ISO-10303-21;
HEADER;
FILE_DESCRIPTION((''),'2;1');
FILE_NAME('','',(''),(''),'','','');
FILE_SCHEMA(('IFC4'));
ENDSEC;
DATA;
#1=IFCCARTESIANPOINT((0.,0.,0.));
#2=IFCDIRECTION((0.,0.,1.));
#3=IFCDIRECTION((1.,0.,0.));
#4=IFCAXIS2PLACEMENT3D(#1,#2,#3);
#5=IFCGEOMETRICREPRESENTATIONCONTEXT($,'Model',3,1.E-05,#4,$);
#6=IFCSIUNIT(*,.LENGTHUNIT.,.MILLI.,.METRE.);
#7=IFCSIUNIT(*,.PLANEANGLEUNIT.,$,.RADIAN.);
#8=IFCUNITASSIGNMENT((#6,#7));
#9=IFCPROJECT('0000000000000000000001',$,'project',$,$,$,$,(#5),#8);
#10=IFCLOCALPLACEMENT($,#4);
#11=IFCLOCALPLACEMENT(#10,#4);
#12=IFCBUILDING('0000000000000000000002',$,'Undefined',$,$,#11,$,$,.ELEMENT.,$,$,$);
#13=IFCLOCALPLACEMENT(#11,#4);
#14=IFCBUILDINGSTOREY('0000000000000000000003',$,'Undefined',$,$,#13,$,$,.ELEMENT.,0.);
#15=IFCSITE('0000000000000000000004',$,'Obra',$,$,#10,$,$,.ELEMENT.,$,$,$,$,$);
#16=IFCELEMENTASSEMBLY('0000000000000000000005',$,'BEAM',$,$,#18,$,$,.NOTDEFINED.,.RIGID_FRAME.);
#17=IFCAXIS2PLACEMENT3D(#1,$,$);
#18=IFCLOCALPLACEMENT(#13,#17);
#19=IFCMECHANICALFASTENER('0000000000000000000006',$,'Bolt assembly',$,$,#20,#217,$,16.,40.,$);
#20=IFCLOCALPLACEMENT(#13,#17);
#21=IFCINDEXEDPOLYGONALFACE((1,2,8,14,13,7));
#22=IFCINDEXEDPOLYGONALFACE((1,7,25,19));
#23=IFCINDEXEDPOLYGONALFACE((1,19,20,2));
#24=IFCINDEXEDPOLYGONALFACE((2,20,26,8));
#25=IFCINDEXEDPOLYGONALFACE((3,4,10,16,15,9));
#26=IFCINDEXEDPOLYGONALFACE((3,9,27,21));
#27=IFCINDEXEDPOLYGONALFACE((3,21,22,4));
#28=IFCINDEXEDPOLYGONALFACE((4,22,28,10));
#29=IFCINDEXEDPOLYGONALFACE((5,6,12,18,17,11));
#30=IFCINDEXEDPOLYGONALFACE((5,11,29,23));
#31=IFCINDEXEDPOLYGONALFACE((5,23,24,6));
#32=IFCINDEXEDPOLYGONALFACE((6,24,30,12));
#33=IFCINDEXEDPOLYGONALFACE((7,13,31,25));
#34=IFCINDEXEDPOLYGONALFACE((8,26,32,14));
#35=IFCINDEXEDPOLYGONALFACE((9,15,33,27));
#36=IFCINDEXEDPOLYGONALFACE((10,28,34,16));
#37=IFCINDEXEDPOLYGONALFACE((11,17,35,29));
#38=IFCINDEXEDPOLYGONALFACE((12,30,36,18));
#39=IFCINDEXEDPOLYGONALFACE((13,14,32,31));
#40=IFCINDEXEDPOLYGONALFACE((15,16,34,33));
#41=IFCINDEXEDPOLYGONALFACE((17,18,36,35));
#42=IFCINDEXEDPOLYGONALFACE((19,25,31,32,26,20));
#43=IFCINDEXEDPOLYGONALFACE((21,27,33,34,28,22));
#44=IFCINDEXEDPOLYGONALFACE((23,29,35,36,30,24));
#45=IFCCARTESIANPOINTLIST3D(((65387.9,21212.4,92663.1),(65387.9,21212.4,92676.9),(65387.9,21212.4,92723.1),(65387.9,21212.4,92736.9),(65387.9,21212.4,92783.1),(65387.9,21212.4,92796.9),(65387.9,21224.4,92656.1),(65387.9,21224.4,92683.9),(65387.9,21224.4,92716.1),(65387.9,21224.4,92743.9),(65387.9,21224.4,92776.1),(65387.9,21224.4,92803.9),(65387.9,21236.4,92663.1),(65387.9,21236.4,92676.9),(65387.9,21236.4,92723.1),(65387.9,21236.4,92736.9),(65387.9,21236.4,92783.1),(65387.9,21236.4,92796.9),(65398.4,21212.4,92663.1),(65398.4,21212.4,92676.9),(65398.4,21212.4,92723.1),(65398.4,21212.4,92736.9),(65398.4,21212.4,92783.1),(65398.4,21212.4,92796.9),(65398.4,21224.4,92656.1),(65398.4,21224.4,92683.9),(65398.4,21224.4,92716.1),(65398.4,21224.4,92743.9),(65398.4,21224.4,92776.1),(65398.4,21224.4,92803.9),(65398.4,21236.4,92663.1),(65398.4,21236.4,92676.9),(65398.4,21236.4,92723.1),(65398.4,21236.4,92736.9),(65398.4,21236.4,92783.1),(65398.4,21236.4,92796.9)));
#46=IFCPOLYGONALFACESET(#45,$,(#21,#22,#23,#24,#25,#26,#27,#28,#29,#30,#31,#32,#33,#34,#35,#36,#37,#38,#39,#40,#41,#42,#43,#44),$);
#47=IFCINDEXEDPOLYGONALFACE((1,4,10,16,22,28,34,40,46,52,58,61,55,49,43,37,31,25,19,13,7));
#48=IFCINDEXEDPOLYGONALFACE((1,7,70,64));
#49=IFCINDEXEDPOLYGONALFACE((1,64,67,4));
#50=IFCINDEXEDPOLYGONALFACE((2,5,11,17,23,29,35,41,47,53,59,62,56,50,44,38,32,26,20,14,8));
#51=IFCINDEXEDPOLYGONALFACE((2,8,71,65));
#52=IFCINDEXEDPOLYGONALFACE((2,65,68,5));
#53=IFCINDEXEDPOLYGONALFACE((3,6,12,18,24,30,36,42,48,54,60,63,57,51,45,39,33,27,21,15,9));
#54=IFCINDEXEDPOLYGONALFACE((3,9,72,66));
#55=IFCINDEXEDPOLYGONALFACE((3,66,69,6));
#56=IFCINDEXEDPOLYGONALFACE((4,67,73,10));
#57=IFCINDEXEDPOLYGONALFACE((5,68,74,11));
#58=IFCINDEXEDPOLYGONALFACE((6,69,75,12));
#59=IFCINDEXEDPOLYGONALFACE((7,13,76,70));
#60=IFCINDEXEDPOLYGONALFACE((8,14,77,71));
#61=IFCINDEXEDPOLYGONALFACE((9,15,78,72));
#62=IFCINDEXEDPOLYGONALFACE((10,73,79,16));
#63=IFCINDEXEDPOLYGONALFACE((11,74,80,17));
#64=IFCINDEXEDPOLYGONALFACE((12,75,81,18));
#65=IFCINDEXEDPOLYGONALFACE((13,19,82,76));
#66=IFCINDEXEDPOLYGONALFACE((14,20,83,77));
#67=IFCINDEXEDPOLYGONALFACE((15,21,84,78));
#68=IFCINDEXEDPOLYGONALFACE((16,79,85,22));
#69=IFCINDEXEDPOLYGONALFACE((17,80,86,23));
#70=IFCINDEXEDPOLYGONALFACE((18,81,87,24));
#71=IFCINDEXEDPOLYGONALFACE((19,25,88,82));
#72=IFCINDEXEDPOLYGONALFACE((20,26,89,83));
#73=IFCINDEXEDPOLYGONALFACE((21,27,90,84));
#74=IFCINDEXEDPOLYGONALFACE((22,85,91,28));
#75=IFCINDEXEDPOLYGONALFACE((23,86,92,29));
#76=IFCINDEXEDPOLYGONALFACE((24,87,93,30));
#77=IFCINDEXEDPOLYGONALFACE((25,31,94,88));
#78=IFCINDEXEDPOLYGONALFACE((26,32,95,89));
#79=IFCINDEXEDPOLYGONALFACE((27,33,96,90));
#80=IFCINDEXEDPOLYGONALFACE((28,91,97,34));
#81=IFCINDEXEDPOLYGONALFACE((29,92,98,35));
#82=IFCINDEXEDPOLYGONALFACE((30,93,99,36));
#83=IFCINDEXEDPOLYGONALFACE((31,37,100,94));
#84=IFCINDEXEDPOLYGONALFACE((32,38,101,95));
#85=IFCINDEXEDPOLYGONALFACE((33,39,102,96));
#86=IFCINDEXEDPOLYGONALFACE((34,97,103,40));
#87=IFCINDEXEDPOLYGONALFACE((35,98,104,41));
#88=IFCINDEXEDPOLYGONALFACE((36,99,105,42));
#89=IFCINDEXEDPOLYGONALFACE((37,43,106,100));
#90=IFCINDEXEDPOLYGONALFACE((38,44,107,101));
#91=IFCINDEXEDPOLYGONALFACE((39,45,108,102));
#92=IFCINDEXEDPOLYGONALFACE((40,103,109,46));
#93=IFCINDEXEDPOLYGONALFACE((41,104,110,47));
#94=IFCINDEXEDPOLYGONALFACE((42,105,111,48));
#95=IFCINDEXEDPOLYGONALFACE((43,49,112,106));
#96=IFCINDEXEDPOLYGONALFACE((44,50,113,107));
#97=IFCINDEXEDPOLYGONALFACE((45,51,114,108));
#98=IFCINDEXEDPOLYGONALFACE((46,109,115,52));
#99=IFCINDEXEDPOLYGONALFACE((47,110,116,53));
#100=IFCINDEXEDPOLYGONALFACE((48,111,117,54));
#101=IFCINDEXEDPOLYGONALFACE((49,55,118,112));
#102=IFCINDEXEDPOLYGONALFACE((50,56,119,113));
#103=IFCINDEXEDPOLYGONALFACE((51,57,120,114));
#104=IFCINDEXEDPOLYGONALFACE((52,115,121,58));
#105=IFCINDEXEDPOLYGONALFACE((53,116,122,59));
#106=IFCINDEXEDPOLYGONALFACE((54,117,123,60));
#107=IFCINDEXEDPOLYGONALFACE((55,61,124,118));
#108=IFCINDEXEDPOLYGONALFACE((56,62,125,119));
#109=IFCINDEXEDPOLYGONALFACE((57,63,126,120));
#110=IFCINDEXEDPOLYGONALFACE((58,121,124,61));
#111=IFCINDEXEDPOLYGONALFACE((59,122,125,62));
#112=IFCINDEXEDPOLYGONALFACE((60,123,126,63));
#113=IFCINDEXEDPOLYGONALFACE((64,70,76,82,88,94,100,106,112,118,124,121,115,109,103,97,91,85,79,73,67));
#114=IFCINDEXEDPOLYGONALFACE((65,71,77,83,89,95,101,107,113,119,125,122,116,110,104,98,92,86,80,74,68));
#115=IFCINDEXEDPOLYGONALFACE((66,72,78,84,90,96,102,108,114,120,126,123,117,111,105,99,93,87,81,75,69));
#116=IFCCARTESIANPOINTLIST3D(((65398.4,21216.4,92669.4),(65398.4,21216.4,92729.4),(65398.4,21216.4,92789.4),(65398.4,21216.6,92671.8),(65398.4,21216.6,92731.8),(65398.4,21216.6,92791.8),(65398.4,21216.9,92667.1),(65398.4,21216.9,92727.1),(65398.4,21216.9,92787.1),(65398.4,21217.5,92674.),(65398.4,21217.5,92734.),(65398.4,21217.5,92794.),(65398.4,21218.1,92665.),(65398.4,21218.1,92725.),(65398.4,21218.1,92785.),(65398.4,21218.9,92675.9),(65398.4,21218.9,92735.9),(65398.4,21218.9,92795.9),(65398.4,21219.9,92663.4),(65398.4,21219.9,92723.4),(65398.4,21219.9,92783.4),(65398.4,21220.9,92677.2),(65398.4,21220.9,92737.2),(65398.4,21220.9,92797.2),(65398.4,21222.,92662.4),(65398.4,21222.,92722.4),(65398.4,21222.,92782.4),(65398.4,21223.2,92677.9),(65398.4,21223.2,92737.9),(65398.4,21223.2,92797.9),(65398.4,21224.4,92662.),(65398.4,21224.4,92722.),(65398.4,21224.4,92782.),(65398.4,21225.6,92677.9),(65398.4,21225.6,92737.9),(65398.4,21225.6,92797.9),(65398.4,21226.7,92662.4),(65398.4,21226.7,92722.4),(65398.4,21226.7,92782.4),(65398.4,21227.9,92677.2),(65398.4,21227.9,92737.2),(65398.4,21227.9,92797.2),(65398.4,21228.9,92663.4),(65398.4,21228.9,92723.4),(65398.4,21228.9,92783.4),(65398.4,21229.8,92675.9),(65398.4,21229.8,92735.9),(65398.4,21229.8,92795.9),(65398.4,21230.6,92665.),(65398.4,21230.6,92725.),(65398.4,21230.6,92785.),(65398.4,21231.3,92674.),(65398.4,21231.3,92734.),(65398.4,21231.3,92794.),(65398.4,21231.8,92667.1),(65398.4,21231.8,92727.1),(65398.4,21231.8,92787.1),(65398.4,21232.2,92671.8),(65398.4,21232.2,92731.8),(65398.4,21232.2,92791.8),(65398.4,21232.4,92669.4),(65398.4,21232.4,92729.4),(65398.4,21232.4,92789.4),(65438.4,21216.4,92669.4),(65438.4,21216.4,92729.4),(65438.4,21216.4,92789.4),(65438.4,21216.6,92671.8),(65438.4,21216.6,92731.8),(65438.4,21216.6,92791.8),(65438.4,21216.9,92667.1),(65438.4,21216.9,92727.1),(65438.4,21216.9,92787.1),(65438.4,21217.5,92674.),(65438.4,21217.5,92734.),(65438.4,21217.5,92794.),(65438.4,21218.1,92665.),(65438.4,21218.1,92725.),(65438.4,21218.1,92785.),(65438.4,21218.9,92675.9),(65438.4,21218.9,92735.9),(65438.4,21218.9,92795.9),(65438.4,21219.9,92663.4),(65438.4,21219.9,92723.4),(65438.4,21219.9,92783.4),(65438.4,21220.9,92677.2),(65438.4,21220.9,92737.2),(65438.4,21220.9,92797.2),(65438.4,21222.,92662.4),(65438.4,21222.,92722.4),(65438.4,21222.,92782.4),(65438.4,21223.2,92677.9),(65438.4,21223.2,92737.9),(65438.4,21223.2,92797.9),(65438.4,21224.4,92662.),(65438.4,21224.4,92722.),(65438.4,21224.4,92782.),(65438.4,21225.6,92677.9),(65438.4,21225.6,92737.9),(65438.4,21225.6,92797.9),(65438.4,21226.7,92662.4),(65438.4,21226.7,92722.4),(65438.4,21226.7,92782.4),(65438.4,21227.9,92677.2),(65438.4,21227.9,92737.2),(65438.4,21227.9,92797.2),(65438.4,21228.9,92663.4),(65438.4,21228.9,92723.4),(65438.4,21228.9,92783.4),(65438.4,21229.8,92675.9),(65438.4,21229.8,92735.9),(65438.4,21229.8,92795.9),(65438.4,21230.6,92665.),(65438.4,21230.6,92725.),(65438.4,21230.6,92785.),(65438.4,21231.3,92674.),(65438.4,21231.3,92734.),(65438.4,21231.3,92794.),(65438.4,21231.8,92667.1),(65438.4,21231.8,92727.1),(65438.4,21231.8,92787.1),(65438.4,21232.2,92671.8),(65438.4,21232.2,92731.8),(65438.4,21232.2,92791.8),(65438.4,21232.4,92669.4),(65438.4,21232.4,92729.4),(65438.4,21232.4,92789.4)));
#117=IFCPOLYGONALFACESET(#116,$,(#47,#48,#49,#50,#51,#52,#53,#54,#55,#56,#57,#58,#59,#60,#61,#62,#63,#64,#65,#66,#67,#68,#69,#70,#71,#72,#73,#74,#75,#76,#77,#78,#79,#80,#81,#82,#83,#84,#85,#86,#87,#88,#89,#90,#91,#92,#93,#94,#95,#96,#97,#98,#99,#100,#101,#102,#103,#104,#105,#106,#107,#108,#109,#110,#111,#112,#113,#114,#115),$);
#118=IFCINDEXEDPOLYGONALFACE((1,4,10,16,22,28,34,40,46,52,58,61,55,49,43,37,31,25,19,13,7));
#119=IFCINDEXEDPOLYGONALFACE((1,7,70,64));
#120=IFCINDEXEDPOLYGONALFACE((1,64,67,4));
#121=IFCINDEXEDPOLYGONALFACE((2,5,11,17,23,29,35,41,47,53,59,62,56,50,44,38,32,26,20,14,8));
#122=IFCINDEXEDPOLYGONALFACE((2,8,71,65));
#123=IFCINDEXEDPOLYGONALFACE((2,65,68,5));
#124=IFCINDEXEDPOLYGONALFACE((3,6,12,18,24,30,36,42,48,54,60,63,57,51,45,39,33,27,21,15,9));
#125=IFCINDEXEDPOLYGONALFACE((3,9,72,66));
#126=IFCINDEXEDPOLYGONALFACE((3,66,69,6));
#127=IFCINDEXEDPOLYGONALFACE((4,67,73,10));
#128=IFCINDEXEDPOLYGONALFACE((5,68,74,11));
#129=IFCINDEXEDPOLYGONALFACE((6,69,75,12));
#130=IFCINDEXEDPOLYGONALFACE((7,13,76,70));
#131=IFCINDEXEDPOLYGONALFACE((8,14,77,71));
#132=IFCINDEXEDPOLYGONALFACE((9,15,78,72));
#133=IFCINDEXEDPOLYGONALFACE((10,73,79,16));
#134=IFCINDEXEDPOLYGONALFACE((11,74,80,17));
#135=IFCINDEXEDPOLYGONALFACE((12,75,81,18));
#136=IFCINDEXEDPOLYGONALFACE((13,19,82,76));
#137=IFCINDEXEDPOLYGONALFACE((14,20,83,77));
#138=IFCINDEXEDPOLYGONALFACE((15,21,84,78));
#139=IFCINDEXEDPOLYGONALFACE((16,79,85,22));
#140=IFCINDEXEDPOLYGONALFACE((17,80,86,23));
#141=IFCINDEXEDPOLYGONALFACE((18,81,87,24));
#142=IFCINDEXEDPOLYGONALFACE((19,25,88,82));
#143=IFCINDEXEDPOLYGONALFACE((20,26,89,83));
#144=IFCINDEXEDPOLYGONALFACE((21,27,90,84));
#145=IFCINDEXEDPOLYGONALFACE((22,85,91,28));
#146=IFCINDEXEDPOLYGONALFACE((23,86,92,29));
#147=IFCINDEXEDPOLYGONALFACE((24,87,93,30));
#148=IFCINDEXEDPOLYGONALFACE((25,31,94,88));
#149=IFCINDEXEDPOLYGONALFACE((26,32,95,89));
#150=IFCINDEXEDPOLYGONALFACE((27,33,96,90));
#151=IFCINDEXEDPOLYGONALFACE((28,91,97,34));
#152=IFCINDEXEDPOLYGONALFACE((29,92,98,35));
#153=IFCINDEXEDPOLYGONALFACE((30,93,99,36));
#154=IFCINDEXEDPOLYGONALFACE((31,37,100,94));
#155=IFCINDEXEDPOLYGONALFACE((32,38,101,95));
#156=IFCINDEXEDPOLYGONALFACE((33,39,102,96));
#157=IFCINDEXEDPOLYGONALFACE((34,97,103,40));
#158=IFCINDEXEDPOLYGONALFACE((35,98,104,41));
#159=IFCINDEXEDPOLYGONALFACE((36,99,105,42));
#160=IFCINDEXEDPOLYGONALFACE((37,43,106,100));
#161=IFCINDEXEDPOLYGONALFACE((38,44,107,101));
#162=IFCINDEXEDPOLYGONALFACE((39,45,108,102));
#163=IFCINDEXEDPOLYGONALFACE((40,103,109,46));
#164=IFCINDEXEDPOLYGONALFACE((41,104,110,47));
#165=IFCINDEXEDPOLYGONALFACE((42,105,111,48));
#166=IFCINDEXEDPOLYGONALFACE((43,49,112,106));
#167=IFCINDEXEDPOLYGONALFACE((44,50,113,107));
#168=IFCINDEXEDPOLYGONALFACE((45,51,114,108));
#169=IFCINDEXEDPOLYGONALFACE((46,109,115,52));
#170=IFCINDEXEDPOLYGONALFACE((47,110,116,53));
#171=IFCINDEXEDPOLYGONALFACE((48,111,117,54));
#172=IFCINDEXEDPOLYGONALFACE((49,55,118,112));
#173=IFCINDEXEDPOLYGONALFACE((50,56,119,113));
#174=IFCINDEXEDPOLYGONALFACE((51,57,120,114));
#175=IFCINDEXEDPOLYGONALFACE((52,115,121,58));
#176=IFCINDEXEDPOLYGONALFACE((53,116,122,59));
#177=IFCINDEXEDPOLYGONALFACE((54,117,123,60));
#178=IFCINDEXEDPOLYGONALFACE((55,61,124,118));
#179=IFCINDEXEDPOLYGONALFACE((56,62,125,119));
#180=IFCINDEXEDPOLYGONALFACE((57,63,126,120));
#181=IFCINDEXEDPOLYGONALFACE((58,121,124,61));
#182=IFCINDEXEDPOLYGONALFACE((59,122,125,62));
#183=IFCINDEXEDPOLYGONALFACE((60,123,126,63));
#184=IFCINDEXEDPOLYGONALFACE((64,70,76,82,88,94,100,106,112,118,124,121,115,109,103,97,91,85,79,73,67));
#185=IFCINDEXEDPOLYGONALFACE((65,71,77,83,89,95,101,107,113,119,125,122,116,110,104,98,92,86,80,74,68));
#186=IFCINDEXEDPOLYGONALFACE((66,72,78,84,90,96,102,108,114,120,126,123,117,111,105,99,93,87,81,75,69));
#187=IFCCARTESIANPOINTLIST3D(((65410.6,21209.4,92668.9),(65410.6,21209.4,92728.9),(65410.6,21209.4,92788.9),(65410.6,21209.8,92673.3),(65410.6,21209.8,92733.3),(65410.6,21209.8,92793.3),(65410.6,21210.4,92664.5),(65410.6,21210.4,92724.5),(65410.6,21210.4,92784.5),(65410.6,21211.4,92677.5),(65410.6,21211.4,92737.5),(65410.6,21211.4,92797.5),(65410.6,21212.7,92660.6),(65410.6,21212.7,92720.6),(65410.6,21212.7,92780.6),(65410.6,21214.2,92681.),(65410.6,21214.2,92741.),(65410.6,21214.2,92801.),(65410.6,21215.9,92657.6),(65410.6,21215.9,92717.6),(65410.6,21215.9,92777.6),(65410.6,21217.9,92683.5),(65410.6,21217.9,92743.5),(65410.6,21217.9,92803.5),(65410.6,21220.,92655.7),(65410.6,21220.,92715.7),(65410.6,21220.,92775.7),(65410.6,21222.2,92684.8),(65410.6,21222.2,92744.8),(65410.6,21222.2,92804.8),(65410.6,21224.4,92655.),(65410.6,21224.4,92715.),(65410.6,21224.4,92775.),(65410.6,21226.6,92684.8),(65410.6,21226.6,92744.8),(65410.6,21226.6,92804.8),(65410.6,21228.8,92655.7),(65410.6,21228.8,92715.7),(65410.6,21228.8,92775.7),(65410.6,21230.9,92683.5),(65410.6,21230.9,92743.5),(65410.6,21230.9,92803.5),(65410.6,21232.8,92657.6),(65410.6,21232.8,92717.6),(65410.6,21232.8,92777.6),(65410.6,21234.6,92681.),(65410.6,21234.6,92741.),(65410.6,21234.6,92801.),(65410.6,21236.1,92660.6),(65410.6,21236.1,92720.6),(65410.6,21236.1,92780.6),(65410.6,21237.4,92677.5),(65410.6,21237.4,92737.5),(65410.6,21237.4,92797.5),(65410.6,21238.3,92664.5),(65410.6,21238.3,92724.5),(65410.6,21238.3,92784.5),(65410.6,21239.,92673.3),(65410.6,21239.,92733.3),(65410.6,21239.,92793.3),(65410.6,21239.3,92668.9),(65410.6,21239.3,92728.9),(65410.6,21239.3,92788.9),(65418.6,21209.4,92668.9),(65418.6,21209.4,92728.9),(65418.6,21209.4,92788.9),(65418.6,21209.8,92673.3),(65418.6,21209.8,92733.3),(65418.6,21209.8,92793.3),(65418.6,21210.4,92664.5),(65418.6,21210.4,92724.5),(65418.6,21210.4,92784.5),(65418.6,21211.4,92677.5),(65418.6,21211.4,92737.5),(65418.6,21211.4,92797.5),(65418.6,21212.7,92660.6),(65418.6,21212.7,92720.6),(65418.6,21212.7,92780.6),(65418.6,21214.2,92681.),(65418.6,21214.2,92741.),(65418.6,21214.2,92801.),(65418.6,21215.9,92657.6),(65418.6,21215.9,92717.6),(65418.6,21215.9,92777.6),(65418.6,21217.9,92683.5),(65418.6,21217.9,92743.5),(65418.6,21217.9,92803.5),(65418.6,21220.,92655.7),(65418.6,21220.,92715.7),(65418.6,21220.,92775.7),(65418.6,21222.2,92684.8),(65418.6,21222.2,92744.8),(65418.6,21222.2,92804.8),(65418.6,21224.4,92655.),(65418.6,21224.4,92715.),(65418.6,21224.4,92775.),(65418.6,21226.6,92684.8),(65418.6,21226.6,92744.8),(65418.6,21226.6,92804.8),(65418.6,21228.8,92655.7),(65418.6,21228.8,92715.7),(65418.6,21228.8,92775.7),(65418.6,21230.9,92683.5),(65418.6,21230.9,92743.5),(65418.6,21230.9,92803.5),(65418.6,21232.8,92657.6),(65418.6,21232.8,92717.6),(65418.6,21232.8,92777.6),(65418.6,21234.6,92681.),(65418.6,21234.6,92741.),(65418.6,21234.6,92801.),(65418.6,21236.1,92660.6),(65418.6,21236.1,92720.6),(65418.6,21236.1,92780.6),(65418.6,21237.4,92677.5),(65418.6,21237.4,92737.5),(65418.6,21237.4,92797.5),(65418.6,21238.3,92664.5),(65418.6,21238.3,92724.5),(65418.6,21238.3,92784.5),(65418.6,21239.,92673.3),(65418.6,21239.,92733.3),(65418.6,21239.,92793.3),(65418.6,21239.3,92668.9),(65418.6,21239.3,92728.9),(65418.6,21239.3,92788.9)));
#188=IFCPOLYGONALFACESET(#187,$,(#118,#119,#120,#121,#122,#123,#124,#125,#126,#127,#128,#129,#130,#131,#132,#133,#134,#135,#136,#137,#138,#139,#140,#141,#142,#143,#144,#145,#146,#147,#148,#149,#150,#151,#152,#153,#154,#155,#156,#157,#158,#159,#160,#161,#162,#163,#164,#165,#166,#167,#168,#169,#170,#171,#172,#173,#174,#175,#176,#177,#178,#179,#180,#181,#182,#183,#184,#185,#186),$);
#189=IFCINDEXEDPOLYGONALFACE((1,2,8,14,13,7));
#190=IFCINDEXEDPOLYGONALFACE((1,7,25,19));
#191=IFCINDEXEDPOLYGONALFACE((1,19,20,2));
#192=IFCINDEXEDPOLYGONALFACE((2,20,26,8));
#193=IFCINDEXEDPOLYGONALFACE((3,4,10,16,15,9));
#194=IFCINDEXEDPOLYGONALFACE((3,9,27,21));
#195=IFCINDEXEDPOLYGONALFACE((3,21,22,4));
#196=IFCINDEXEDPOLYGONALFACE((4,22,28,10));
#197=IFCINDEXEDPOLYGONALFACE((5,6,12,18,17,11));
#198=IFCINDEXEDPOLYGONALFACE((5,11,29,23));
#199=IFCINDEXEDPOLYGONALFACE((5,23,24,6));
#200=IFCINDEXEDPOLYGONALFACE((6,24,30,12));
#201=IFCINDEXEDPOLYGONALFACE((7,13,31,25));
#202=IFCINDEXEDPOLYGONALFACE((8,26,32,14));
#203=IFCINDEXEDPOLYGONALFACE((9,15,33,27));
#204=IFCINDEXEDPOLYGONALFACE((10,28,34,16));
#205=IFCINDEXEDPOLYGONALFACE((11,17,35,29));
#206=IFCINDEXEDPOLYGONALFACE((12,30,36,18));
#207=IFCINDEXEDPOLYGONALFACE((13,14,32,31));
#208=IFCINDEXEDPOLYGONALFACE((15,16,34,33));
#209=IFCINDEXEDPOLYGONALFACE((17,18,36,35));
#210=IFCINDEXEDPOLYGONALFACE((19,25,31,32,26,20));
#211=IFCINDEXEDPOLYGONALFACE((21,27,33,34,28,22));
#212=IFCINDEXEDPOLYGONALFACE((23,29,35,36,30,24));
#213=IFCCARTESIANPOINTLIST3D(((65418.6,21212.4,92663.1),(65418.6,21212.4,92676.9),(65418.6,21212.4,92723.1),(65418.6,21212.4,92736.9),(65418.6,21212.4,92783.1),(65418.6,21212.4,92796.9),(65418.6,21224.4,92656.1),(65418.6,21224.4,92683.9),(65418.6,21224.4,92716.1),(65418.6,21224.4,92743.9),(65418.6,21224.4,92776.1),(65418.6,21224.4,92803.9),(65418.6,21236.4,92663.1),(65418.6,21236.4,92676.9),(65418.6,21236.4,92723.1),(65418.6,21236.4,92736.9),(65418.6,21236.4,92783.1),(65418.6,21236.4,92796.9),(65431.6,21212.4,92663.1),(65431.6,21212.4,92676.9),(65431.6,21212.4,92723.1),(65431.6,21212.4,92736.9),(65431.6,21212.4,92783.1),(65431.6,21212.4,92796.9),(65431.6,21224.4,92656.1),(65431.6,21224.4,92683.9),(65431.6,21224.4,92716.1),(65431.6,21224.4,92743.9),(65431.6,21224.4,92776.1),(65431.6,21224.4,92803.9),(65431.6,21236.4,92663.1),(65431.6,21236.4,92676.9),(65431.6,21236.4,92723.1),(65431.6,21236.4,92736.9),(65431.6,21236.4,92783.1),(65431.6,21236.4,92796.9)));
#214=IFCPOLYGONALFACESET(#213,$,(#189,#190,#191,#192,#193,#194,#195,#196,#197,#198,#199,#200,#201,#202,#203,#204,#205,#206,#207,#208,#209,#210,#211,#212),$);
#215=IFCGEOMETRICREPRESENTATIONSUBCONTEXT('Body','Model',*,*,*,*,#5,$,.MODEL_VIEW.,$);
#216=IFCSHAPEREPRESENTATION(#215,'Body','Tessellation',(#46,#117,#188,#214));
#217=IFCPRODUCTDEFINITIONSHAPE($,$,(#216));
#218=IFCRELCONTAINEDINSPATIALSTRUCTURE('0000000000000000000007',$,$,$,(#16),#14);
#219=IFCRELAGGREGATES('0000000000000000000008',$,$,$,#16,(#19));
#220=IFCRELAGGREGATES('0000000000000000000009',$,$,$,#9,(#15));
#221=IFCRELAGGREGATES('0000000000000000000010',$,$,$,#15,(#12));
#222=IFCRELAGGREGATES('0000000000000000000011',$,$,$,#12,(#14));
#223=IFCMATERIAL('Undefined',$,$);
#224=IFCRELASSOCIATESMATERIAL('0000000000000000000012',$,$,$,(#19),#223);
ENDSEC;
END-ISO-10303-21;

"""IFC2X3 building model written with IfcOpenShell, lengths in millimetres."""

from ifc_helpers import new_model, si_unit, frame, origin_with_axes, origin_2d_with_axis, place, context, subcontext, project, spatial, polyline, circle, outline, extrude, source, transform, mapped, material, element, aggregate, save


model = new_model("IFC2X3")

# Units and contexts
model_context = context("Model", 3, precision=1e-05, world=origin_with_axes())
body_context = subcontext(model_context, "Body", "Model", "MODEL_VIEW")
ifc_project = project(units=[si_unit("LENGTHUNIT", "METRE", prefix="MILLI"), si_unit("PLANEANGLEUNIT", "RADIAN")], contexts=[model_context])

# Site, building, storey
site_placement = place(None, origin_with_axes())
site = spatial("IfcSite", under=ifc_project, at=site_placement, Name="Obra", CompositionType="ELEMENT")
building_placement = place(site_placement, origin_with_axes())
building = spatial("IfcBuilding", under=site, at=building_placement, Name="Undefined", CompositionType="ELEMENT")
storey_placement = place(building_placement, origin_with_axes())
storey = spatial("IfcBuildingStorey", under=building, at=storey_placement, Name="Undefined", CompositionType="ELEMENT", Elevation=0.0)

# Shared definitions
ifc_material_1 = material(Name="Undefined")

# Element assembly
shared_shape_1 = source(origin_with_axes(), body_context, "Body", "SweptSolid", [
    extrude(outline(polyline([(13.9, 0.0), (6.9, 12.0), (-6.9, 12.0), (-13.9, 0.0), (-6.9, -12.0), (6.9, -12.0), (13.9, 0.0)])), frame((0.0, -19.7, 0.0), z_axis=(0.0, 1.0, 0.0), x_axis=(1.0, 0.0, 0.0)), (0.0, 0.0, 1.0), 10.6),
    extrude(circle(Radius=8.0, at=origin_2d_with_axis()), frame((0.0, -9.1, 0.0), z_axis=(0.0, 1.0, 0.0), x_axis=(1.0, 0.0, 0.0)), (0.0, 0.0, 1.0), 40.0),
    extrude(circle(Radius=15.0, at=origin_2d_with_axis()), frame((0.0, 3.1, 0.0), z_axis=(0.0, 1.0, 0.0), x_axis=(1.0, 0.0, 0.0)), (0.0, 0.0, 1.0), 8.0),
    extrude(outline(polyline([(13.9, 0.0), (6.9, 12.0), (-6.9, 12.0), (-13.9, 0.0), (-6.9, -12.0), (6.9, -12.0), (13.9, 0.0)])), frame((0.0, 11.1, 0.0), z_axis=(0.0, 1.0, 0.0), x_axis=(1.0, 0.0, 0.0)), (0.0, 0.0, 1.0), 13.0),
])
assembly_1_placement = place(storey_placement, origin_with_axes())
assembly_1 = element("IfcElementAssembly", 1, at=assembly_1_placement, inside=storey, Name="BEAM", AssemblyPlace="NOTDEFINED", PredefinedType="RIGID_FRAME")

# Mechanical fastener
mechanical_fastener_1_placement = place(assembly_1_placement, frame((65407.5, 21274.4, 92850.0), z_axis=(0.000002, -1.0, 0.0), x_axis=(0.0, 0.0, -1.0)))
mechanical_fastener_1 = element("IfcMechanicalFastener", 2, at=mechanical_fastener_1_placement, material=ifc_material_1, Name="Bolt assembly", NominalDiameter=16.0, NominalLength=40.0, context=body_context, shape_type="MappedRepresentation", body=[
    mapped(shared_shape_1, transform((60.0, 0.0, 50.0))),
    mapped(shared_shape_1, transform((120.0, 0.0, 50.0))),
    mapped(shared_shape_1, transform((180.0, 0.0, 50.0))),
])
aggregate(assembly_1, [mechanical_fastener_1])

save(model, "model.ifc")
